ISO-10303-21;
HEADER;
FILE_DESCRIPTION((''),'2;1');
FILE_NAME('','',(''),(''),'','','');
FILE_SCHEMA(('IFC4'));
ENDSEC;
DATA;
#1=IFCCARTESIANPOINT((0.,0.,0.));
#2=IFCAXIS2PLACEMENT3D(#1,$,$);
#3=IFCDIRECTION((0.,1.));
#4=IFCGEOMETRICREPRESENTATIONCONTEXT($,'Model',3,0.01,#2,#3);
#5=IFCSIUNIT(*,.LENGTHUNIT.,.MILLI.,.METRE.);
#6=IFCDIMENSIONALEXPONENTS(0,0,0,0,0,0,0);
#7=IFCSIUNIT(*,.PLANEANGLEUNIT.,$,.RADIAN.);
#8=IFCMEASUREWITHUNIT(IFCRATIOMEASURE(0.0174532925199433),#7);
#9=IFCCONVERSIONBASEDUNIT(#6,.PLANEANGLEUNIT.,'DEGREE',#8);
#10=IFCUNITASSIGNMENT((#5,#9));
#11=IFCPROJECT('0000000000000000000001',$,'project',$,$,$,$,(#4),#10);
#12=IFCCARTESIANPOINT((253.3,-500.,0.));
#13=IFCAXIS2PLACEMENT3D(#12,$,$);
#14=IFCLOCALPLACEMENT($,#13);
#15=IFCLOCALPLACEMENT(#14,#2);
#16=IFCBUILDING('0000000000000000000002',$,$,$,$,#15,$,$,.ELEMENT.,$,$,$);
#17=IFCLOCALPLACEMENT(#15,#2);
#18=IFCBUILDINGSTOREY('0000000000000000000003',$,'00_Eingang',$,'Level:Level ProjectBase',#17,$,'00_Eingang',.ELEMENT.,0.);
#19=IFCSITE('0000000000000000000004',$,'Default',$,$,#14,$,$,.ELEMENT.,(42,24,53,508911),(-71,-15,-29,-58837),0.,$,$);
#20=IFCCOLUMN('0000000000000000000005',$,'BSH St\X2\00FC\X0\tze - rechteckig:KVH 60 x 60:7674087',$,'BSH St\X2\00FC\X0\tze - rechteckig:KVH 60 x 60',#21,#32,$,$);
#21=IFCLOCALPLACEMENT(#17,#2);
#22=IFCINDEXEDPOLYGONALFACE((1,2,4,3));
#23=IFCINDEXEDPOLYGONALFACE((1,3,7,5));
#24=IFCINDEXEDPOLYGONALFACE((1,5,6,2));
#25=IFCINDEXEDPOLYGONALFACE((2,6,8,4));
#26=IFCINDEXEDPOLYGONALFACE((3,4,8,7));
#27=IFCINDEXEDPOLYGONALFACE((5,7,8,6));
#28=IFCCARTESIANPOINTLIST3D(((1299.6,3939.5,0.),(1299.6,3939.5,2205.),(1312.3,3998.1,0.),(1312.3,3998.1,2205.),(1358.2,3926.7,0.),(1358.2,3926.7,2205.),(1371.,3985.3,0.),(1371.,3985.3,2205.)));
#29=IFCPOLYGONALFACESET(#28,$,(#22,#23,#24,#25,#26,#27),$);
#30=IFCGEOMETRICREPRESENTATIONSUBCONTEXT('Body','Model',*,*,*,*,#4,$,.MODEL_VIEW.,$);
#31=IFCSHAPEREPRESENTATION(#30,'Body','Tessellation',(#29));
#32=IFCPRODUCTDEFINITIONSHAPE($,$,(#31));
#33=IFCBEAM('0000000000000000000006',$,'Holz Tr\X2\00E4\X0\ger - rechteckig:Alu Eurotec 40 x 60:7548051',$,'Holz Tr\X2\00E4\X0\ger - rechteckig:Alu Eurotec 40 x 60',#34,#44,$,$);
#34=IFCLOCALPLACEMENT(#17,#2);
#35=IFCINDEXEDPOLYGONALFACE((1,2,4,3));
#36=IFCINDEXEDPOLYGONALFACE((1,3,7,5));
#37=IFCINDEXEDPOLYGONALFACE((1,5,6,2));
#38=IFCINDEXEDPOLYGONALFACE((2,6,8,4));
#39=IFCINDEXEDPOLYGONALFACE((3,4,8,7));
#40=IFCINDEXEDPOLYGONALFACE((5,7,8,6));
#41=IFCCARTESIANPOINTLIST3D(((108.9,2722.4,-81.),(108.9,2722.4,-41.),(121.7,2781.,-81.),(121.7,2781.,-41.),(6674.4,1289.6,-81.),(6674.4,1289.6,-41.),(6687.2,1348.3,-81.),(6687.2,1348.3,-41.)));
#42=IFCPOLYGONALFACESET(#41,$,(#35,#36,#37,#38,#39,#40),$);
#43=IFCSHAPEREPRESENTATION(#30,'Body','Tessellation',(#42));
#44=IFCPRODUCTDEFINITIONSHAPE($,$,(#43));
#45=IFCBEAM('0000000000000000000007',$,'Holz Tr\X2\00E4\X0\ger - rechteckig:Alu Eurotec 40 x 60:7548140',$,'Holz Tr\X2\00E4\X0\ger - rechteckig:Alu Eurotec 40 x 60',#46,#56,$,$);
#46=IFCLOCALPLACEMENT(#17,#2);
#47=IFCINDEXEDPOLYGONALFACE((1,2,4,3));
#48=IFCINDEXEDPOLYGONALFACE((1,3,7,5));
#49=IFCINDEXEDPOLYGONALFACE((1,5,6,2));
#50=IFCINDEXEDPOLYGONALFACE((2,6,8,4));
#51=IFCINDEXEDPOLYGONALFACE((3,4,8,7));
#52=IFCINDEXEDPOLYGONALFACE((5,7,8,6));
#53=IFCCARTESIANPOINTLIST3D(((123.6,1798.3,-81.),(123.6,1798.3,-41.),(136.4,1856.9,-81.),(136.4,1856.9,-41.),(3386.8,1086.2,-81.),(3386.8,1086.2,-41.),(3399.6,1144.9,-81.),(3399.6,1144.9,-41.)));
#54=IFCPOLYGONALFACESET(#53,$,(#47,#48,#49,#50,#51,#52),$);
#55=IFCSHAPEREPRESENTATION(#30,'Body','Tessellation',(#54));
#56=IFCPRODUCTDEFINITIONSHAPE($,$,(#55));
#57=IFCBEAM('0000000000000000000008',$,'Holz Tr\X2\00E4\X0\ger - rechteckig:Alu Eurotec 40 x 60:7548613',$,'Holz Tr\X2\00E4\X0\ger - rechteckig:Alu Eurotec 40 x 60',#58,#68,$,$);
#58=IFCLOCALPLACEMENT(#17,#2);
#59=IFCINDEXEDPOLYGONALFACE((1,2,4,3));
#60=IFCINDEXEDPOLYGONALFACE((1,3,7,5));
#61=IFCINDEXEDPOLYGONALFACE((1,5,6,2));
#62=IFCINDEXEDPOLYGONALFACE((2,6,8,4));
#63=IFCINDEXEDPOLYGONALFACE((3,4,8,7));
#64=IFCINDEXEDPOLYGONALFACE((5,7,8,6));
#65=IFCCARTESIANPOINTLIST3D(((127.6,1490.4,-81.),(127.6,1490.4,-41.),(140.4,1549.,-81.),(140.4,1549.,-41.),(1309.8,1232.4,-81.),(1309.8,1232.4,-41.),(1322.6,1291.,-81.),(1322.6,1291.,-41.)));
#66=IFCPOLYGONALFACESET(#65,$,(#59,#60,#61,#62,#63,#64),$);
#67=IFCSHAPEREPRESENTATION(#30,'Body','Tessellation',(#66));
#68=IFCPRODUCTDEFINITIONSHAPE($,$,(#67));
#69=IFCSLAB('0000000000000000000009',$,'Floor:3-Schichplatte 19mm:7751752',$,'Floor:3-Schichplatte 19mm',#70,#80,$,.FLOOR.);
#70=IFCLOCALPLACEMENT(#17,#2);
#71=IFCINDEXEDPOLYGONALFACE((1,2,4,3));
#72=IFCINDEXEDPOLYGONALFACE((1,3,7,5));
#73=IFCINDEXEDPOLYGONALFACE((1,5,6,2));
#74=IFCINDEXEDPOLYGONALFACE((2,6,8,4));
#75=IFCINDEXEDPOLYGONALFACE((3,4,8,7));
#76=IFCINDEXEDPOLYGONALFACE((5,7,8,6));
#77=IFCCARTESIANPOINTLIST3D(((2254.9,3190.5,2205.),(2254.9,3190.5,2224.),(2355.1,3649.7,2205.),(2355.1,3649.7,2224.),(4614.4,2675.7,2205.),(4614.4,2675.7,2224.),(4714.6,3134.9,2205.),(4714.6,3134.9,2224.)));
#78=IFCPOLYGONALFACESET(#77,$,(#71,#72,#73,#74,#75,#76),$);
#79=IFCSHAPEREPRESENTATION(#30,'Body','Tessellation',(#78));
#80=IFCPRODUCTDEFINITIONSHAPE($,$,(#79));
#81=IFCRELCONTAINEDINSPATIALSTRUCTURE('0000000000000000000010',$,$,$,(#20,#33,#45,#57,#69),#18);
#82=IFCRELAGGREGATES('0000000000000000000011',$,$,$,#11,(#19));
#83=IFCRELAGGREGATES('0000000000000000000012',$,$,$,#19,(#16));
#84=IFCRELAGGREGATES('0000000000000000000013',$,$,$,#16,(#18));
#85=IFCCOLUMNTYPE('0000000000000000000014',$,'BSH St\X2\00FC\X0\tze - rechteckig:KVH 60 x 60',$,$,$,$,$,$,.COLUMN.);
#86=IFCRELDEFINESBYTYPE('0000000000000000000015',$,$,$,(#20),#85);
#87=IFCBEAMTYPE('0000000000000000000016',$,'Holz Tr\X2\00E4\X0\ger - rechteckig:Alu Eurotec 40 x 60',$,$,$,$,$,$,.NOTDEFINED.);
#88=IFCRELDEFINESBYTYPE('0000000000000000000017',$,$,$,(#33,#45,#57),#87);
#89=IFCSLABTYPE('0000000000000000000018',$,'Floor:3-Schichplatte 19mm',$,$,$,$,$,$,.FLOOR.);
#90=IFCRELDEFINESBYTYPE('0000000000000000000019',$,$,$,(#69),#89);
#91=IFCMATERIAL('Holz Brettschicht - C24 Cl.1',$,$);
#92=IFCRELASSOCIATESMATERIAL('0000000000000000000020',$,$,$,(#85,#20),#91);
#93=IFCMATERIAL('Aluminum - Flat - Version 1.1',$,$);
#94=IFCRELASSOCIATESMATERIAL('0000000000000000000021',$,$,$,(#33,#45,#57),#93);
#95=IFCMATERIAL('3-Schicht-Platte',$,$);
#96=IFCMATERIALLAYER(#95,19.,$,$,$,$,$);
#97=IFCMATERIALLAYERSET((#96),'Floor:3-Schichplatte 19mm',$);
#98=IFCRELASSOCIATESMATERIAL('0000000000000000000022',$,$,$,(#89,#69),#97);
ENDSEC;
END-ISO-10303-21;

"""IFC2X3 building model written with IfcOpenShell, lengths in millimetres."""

from ifc_helpers import new_model, entity, si_unit, converted_unit, direction, frame, frame_2d, origin, place, context, subcontext, project, spatial, polyline, rectangle, outline, extrude, source, transform, mapped, material, layer, layer_set, layer_usage, type_object, type_shapes, element, save


model = new_model("IFC2X3")

# Units and contexts
model_context = context("Model", 3, precision=0.01, world=origin(), true_north=direction((0.0, 1.0)))
body_context = subcontext(model_context, "Body", "Model", "MODEL_VIEW")
ifc_project = project(units=[si_unit("LENGTHUNIT", "METRE", prefix="MILLI"), converted_unit("PLANEANGLEUNIT", "DEGREE", entity("IfcRatioMeasure", 0.0174532925199433), si_unit("PLANEANGLEUNIT", "RADIAN"), dimensions=[0, 0, 0, 0, 0, 0, 0])], contexts=[model_context])

# Site, building, storey
site_placement = place(None, frame((253.3, -500.0, 0.0)))
site = spatial("IfcSite", under=ifc_project, at=site_placement, Name="Default", CompositionType="ELEMENT", RefLatitude=(42, 24, 53, 508911), RefLongitude=(-71, -15, -29, -58837), RefElevation=0.0)
building_placement = place(site_placement, origin())
building = spatial("IfcBuilding", under=site, at=building_placement, CompositionType="ELEMENT")
storey_placement = place(building_placement, origin())
storey = spatial("IfcBuildingStorey", under=building, at=storey_placement, Name="00_Eingang", ObjectType="Level:Level ProjectBase", LongName="00_Eingang", CompositionType="ELEMENT", Elevation=0.0)

# Column
ifc_material_1 = material(Name="Holz Brettschicht - C24 Cl.1")
column_type_1 = type_object("IfcColumnType", Name="BSH Stütze - rechteckig:KVH 60 x 60", PredefinedType="COLUMN", material=ifc_material_1)
shared_shape_1 = source(origin(), body_context, "Body", "SweptSolid", [
    extrude(rectangle(XDim=60.0, YDim=60.0, at=frame_2d((0.0, 0.0), x_axis=(1.0, 0.0))), frame((1335.3, 3962.4, 0.0), z_axis=(0.0, 0.0, 1.0), x_axis=(0.213201, 0.977008, 0.0)), (0.0, 0.0, 1.0), 2205.0),
])
type_shapes(column_type_1, [shared_shape_1])
column_1_placement = place(storey_placement, origin())
element("IfcColumn", 1, at=column_1_placement, inside=storey, type_object=column_type_1, material=ifc_material_1, Name="BSH Stütze - rechteckig:KVH 60 x 60:7674087", ObjectType="BSH Stütze - rechteckig:KVH 60 x 60", context=body_context, shape_type="MappedRepresentation", body=[
    mapped(shared_shape_1, transform((0.0, 0.0, 0.0), scale=1.0)),
])

# Beams
ifc_material_2 = material(Name="Aluminum - Flat - Version 1.1")
beam_type = type_object("IfcBeamType", Name="Holz Träger - rechteckig:Alu Eurotec 40 x 60", PredefinedType="NOTDEFINED")
beam_1_placement = place(storey_placement, frame((115.3, 2751.7, -41.0), z_axis=(0.0, 0.0, 1.0), x_axis=(0.977008, -0.213201, 0.0)))
element("IfcBeam", 2, at=beam_1_placement, inside=storey, type_object=beam_type, material=ifc_material_2, Name="Holz Träger - rechteckig:Alu Eurotec 40 x 60:7548051", ObjectType="Holz Träger - rechteckig:Alu Eurotec 40 x 60", context=body_context, shape_type="SweptSolid", body=[
    extrude(rectangle(XDim=40.0, YDim=60.0, at=frame_2d((0.0, 0.0), x_axis=(1.0, 0.0))), frame((0.0, 0.0, -20.0), z_axis=(1.0, 0.0, 0.0), x_axis=(0.0, 0.0, -1.0)), (0.0, 0.0, 1.0), 6720.0),
])
beam_2_placement = place(storey_placement, frame((129.6, 1827.7, -41.0), z_axis=(0.0, 0.0, 1.0), x_axis=(0.977008, -0.213201, 0.0)))
element("IfcBeam", 3, at=beam_2_placement, inside=storey, type_object=beam_type, material=ifc_material_2, Name="Holz Träger - rechteckig:Alu Eurotec 40 x 60:7548140", ObjectType="Holz Träger - rechteckig:Alu Eurotec 40 x 60", context=body_context, shape_type="SweptSolid", body=[
    extrude(rectangle(XDim=40.0, YDim=60.0, at=frame_2d((0.0, 0.0), x_axis=(1.0, 0.0))), frame((0.4, 0.0, -20.0), z_axis=(1.0, 0.0, 0.0), x_axis=(0.0, 0.0, -1.0)), (0.0, 0.0, 1.0), 3340.0),
])
beam_3_placement = place(storey_placement, frame((134.0, 1519.7, -41.0), z_axis=(0.0, 0.0, 1.0), x_axis=(0.977008, -0.213201, 0.0)))
element("IfcBeam", 4, at=beam_3_placement, inside=storey, type_object=beam_type, material=ifc_material_2, Name="Holz Träger - rechteckig:Alu Eurotec 40 x 60:7548613", ObjectType="Holz Träger - rechteckig:Alu Eurotec 40 x 60", context=body_context, shape_type="SweptSolid", body=[
    extrude(rectangle(XDim=40.0, YDim=60.0, at=frame_2d((0.0, 0.0), x_axis=(1.0, 0.0))), frame((0.0, 0.0, -20.0), z_axis=(1.0, 0.0, 0.0), x_axis=(0.0, 0.0, -1.0)), (0.0, 0.0, 1.0), 1210.0),
])

# Slab
ifc_material_3 = material(Name="3-Schicht-Platte")
ifc_layer = layer(ifc_material_3, 19.0)
ifc_layer_set = layer_set([ifc_layer], Name="Floor:3-Schichplatte 19mm")
ifc_layer_usage_1 = layer_usage(ifc_layer_set, "AXIS3", "POSITIVE", 0.0)
slab_type_1 = type_object("IfcSlabType", Name="Floor:3-Schichplatte 19mm", PredefinedType="FLOOR", material=ifc_layer_set)
slab_1_placement = place(storey_placement, origin())
element("IfcSlab", 5, at=slab_1_placement, inside=storey, type_object=slab_type_1, material=ifc_layer_usage_1, Name="Floor:3-Schichplatte 19mm:7751752", ObjectType="Floor:3-Schichplatte 19mm", PredefinedType="FLOOR", context=body_context, shape_type="SweptSolid", body=[
    extrude(outline(polyline([(-1207.5, -235.0), (1207.5, -235.0), (1207.5, 235.0), (-1207.5, 235.0), (-1207.5, -235.0)])), frame((3484.8, 3162.7, 2224.0), z_axis=(0.0, 0.0, -1.0), x_axis=(0.977008, -0.213201, 0.0)), (0.0, 0.0, 1.0), 19.0),
])

save(model, "model.ifc")
